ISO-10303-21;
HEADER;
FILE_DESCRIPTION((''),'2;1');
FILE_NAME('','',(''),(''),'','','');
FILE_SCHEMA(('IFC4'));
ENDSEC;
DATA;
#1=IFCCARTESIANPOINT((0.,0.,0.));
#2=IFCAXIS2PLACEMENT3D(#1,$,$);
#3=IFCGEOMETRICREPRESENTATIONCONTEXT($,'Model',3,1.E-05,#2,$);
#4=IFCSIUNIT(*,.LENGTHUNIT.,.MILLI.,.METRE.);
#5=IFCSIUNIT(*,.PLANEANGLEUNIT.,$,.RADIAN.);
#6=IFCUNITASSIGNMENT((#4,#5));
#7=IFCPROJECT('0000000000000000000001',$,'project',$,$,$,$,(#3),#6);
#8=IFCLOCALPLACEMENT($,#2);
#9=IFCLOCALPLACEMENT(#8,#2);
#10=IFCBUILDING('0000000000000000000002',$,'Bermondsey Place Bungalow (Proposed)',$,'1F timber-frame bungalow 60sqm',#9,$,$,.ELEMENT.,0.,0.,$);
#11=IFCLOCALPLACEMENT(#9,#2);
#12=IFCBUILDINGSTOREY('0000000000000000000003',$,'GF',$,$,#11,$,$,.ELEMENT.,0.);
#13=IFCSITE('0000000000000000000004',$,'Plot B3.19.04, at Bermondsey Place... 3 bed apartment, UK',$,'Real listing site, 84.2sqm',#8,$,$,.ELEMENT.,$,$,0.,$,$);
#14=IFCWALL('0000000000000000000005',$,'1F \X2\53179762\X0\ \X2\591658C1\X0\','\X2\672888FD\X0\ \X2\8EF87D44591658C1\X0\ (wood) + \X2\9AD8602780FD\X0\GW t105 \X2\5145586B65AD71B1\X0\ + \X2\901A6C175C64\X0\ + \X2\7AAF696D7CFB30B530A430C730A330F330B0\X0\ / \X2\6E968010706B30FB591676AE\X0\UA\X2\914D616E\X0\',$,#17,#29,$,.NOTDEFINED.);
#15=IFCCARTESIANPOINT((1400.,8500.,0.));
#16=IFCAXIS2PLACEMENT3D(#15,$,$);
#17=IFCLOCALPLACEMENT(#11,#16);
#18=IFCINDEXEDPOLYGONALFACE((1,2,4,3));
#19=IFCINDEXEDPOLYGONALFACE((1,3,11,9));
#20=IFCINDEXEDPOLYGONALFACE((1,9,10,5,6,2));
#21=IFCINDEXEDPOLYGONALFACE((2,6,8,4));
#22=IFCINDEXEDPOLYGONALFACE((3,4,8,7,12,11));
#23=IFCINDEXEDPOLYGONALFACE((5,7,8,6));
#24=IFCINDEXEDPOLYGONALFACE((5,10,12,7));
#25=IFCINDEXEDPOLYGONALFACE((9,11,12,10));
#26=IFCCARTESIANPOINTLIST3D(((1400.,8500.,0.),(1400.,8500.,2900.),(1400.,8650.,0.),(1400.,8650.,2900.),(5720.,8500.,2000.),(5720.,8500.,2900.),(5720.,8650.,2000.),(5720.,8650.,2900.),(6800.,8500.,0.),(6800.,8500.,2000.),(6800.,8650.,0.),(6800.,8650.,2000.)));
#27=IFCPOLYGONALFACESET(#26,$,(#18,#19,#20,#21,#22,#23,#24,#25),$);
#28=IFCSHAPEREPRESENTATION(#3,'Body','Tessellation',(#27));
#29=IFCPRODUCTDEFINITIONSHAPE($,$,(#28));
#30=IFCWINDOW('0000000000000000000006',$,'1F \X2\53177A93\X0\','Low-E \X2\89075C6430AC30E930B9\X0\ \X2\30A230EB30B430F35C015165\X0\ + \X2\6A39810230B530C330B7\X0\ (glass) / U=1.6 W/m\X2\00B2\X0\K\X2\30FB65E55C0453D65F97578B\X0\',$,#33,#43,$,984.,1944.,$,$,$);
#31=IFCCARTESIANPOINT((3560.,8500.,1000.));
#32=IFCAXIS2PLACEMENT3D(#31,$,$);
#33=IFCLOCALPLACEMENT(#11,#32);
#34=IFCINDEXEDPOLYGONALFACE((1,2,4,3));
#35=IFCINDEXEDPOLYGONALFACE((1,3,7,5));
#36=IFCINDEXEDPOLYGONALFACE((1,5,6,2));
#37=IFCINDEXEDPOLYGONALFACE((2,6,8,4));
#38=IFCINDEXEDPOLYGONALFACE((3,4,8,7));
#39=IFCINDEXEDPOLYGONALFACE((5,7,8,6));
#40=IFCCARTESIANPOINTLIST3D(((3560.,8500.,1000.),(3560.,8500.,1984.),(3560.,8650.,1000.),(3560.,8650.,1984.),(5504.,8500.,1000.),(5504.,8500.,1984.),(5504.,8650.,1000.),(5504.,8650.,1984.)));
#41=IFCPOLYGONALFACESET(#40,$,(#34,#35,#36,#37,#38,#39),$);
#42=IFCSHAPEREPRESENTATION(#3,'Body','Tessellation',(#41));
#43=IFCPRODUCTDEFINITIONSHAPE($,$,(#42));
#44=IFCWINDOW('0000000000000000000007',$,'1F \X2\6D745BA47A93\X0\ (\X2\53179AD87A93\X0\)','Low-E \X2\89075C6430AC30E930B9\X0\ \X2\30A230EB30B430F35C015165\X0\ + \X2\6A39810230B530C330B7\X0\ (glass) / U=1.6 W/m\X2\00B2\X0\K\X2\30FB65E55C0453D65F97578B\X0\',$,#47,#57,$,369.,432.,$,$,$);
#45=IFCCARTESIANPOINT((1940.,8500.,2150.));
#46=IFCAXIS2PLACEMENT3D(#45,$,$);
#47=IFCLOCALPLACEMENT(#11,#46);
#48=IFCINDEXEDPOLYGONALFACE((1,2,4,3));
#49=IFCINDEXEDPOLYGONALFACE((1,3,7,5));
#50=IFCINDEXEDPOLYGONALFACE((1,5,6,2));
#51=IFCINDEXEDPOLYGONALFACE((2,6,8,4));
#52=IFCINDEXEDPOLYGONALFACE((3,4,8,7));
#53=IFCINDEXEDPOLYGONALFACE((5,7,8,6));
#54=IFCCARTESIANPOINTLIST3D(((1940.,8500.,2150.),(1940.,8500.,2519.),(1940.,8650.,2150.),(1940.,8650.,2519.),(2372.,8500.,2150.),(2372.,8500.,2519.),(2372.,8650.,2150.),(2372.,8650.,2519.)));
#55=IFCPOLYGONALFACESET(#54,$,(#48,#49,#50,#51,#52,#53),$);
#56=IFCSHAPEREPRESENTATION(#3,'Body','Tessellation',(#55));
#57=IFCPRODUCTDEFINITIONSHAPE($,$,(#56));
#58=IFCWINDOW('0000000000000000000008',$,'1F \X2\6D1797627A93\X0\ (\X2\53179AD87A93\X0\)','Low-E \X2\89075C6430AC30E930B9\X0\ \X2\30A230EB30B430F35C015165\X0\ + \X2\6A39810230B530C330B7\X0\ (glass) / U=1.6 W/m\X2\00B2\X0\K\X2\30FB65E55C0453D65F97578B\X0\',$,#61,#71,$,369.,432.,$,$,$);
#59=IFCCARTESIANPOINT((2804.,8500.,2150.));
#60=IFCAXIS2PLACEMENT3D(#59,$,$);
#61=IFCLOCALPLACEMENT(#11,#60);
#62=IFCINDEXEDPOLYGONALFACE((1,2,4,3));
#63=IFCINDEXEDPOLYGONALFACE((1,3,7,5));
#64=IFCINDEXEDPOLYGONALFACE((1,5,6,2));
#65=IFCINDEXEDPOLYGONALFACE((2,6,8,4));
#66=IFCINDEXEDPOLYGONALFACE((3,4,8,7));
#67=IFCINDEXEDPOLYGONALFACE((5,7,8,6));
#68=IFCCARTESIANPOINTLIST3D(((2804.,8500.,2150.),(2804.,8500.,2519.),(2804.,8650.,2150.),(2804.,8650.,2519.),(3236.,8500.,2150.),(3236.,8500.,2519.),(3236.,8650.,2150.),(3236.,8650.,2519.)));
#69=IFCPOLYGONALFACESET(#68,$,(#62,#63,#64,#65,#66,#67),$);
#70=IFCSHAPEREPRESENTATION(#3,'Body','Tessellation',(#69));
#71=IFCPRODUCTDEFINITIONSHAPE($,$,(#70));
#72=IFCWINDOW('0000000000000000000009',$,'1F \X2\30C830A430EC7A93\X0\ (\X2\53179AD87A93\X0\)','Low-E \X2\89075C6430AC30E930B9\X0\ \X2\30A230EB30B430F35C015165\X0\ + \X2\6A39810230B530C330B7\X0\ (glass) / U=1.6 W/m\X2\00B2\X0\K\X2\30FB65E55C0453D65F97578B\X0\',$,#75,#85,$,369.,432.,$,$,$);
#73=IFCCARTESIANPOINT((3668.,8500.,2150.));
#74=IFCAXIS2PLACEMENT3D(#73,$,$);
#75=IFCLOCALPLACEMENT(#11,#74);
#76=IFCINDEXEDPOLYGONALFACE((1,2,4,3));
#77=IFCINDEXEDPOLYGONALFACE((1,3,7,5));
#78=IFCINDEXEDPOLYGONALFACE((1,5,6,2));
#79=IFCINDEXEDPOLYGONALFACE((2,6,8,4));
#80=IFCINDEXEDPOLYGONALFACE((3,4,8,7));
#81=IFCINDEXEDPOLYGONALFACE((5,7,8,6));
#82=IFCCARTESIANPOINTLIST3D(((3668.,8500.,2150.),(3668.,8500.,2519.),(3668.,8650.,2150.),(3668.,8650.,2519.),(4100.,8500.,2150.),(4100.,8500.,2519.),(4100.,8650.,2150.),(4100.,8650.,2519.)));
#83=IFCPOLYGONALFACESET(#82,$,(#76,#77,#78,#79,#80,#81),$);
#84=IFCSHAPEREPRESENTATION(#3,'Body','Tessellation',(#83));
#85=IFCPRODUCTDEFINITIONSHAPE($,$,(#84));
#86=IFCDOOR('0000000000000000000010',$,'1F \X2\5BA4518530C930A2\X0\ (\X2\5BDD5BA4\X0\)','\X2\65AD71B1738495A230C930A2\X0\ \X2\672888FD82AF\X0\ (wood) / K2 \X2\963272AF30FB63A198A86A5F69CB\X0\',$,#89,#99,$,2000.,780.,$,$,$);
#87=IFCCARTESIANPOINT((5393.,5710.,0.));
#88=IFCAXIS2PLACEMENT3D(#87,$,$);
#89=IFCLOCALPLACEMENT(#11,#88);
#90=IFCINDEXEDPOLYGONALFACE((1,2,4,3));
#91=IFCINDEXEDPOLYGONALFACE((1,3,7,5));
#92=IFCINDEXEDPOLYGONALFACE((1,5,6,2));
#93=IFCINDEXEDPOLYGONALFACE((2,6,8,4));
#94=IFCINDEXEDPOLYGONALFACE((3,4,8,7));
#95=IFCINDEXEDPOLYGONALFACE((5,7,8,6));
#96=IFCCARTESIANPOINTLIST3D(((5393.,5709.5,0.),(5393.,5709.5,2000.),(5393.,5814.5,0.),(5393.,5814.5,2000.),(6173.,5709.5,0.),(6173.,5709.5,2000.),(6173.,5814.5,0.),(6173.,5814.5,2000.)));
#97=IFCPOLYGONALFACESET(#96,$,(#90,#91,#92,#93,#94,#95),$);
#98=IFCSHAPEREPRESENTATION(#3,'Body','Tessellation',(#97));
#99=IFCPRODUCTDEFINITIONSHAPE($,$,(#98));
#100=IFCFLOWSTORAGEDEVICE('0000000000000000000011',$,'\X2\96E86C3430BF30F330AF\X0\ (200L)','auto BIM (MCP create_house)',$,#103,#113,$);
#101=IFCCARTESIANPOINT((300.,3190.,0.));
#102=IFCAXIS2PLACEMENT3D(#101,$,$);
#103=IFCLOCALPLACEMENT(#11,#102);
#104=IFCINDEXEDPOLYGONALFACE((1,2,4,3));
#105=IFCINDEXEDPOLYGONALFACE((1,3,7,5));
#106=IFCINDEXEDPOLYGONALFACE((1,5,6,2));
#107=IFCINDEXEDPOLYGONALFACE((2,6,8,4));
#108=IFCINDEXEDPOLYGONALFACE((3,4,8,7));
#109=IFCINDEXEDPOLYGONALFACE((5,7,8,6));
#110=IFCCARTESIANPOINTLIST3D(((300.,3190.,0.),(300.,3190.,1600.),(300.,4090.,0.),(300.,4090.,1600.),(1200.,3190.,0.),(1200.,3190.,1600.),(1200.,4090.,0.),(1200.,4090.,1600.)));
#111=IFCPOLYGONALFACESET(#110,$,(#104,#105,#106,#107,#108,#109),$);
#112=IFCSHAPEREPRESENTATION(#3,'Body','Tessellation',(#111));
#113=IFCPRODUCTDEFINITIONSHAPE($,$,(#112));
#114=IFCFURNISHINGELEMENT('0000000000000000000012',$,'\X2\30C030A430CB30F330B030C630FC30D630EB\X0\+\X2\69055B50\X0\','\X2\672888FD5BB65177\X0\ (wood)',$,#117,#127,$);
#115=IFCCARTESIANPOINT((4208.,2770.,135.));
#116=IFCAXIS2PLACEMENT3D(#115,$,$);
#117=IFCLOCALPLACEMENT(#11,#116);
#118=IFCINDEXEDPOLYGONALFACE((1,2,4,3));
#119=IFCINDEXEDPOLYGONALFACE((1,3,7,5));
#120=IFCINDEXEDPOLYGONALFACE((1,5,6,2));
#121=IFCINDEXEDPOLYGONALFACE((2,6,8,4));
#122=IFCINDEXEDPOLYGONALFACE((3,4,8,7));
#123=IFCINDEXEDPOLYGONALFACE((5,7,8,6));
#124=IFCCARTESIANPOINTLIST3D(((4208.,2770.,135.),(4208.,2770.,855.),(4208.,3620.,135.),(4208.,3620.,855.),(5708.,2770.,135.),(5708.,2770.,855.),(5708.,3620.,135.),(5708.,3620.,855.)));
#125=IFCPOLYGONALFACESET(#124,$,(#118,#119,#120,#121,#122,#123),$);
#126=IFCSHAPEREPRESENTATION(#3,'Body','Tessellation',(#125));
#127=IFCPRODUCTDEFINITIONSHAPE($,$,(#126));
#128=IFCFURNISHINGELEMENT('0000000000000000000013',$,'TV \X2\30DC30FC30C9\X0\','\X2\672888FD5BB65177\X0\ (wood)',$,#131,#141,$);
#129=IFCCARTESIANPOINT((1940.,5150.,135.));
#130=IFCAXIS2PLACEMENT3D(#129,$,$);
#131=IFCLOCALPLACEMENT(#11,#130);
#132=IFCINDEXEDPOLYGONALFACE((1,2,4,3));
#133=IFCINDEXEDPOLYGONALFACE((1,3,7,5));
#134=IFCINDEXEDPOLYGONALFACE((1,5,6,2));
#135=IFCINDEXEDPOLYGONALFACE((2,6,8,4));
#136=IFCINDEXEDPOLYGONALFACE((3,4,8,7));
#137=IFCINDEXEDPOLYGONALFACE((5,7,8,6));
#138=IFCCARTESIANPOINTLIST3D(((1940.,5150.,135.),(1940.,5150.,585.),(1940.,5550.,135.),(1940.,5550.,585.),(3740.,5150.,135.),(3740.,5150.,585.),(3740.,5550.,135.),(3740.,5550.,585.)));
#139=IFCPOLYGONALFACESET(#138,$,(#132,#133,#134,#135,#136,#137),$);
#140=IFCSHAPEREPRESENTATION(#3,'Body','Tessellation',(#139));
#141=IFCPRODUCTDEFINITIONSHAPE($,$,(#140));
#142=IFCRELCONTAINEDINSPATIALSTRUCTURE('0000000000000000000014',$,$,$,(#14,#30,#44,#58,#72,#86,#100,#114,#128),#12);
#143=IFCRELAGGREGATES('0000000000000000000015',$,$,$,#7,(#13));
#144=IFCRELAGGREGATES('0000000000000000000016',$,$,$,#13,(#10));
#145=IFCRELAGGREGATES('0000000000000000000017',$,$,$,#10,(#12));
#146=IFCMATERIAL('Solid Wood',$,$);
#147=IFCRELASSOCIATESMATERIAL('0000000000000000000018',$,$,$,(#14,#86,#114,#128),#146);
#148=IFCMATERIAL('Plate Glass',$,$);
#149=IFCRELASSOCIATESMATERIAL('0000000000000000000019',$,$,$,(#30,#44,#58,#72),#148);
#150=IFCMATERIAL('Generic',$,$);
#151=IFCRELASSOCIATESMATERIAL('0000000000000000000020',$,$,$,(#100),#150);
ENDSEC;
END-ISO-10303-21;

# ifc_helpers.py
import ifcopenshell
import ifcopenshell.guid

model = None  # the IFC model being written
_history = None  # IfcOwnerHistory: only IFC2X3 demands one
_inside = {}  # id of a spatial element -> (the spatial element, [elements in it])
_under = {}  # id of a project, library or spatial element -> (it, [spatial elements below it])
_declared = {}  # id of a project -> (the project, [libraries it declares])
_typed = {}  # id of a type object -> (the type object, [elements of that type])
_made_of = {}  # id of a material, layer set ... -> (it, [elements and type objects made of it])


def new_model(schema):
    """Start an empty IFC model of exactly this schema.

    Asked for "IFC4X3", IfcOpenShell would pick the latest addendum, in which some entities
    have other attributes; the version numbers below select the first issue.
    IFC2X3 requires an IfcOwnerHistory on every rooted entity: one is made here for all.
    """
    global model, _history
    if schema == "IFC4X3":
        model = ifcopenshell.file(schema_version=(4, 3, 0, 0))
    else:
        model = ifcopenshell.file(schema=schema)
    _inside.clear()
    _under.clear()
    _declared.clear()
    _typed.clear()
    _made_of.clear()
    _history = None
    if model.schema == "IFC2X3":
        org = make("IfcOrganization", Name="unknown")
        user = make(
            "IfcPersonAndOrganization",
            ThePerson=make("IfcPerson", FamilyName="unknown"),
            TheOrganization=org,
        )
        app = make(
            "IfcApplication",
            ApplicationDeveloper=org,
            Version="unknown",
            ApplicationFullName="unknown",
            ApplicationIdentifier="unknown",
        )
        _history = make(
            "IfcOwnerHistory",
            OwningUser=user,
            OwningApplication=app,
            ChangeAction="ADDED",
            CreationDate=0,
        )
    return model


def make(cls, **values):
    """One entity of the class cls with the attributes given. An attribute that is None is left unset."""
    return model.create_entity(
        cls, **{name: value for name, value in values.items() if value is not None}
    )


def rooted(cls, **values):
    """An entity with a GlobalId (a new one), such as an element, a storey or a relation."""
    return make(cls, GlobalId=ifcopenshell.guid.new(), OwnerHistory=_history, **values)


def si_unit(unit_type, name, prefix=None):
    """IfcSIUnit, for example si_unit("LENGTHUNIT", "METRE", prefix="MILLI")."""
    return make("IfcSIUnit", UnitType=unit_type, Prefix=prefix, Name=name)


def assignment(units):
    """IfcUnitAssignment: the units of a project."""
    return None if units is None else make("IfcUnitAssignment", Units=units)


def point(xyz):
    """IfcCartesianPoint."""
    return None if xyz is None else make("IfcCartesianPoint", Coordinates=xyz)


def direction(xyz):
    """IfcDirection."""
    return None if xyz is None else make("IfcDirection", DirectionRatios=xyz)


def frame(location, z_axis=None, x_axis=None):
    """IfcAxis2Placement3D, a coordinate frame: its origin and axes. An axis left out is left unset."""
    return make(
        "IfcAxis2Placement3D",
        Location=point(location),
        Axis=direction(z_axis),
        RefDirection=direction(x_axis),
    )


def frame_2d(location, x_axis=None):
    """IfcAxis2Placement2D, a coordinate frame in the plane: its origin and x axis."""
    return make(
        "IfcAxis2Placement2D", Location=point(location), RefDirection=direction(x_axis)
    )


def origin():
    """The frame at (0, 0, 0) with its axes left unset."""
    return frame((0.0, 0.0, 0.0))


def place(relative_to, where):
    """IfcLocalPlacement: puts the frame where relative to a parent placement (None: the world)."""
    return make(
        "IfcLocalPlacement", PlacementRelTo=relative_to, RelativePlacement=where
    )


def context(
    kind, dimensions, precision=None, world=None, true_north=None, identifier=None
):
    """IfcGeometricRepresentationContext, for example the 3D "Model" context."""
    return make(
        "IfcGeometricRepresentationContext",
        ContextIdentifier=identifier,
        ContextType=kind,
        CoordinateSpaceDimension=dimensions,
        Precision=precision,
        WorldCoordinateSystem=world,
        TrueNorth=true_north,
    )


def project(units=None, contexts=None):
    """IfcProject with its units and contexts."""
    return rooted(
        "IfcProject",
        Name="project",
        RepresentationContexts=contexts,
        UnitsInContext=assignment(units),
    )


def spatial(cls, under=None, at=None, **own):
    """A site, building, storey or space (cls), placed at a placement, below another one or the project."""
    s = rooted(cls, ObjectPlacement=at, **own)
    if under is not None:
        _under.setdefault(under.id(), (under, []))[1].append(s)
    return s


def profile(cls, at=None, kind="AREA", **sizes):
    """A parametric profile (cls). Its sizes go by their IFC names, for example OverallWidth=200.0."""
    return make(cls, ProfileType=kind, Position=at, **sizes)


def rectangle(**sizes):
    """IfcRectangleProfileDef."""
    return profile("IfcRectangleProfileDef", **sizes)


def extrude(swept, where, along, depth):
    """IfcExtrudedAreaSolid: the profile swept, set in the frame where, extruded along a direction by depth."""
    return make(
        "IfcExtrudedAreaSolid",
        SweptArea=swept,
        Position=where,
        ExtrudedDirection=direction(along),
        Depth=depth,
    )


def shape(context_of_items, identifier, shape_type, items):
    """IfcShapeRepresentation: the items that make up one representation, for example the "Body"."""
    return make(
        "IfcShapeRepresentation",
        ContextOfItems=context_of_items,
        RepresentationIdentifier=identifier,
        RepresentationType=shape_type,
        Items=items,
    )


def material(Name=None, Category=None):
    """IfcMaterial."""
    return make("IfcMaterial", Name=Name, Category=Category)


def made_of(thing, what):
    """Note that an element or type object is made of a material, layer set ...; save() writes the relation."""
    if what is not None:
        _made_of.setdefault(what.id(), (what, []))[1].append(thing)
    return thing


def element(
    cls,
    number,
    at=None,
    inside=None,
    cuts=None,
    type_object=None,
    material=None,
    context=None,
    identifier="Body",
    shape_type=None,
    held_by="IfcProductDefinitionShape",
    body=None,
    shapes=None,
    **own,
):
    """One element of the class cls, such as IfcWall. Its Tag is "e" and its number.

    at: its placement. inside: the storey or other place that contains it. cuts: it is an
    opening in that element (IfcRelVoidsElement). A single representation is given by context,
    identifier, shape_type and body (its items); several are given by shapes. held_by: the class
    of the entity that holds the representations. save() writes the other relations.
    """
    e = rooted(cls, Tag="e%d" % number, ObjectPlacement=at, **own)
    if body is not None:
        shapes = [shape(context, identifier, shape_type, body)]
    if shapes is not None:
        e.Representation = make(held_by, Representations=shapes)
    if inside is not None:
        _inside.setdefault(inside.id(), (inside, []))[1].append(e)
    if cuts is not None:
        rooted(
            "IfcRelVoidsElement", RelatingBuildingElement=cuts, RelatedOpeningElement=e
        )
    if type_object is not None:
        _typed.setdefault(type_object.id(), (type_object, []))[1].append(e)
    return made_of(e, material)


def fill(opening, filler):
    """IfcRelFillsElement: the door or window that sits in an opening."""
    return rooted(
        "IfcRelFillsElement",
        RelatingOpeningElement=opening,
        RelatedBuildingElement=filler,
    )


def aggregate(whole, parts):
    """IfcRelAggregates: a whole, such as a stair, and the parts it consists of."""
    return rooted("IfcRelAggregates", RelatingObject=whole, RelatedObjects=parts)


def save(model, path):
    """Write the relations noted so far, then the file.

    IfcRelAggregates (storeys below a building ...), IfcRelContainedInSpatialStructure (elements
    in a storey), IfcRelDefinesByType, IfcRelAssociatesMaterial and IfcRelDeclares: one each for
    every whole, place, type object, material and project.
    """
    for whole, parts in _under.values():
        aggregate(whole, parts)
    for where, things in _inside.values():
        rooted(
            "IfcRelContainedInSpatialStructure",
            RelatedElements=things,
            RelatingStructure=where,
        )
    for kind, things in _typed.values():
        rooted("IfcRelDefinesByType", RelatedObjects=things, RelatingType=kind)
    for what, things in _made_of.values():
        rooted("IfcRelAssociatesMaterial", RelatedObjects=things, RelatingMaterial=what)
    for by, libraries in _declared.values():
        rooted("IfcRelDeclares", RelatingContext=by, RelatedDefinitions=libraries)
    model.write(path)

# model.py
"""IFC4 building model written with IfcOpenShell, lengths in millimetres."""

from ifc_helpers import new_model, si_unit, frame, frame_2d, origin, place, context, project, spatial, rectangle, extrude, material, element, fill, save


model = new_model("IFC4")

# Units and contexts
model_context = context("Model", 3, precision=1e-05, world=origin())
ifc_project = project(units=[si_unit("LENGTHUNIT", "METRE", prefix="MILLI"), si_unit("PLANEANGLEUNIT", "RADIAN")], contexts=[model_context])

# Site, building, storey
site_placement = place(None, origin())
site = spatial("IfcSite", under=ifc_project, at=site_placement, Name="Plot B3.19.04, at Bermondsey Place... 3 bed apartment, UK", ObjectType="Real listing site, 84.2sqm", CompositionType="ELEMENT", RefElevation=0.0)
building_placement = place(site_placement, origin())
building = spatial("IfcBuilding", under=site, at=building_placement, Name="Bermondsey Place Bungalow (Proposed)", ObjectType="1F timber-frame bungalow 60sqm", CompositionType="ELEMENT", ElevationOfRefHeight=0.0, ElevationOfTerrain=0.0)
storey_placement = place(building_placement, origin())
storey = spatial("IfcBuildingStorey", under=building, at=storey_placement, Name="GF", CompositionType="ELEMENT", Elevation=0.0)

# Wall, openings, windows
ifc_material_1 = material(Name="Solid Wood")
wall_1_placement = place(storey_placement, frame((1400.0, 8500.0, 0.0)))
wall_1 = element("IfcWall", 1, at=wall_1_placement, inside=storey, material=ifc_material_1, Name="1F 北面 外壁", Description="木製 軸組外壁 (wood) + 高性能GW t105 充填断熱 + 通気層 + 窯業系サイディング / 準耐火・外皮UA配慮", PredefinedType="NOTDEFINED", context=model_context, shape_type="SweptSolid", body=[
    extrude(rectangle(XDim=5400.0, YDim=150.0, at=frame_2d((2700.0, 75.0))), frame((1400.0, 8500.0, 0.0)), (0.0, 0.0, 1.0), 2900.0),
])
opening_1_placement = place(storey_placement, frame((3560.0, 8500.0, 1000.0)))
opening_1 = element("IfcOpeningElement", 2, at=opening_1_placement, cuts=wall_1, PredefinedType="NOTDEFINED", context=model_context, shape_type="SweptSolid", body=[
    extrude(rectangle(XDim=1944.0, YDim=150.0, at=frame_2d((972.0, 75.0))), frame((3560.0, 8500.0, 1000.0)), (0.0, 0.0, 1.0), 984.0),
])
opening_2_placement = place(storey_placement, frame((1940.0, 8500.0, 2150.0)))
opening_2 = element("IfcOpeningElement", 3, at=opening_2_placement, cuts=wall_1, PredefinedType="NOTDEFINED", context=model_context, shape_type="SweptSolid", body=[
    extrude(rectangle(XDim=432.0, YDim=150.0, at=frame_2d((216.0, 75.0))), frame((1940.0, 8500.0, 2150.0)), (0.0, 0.0, 1.0), 369.0),
])
opening_3_placement = place(storey_placement, frame((2804.0, 8500.0, 2150.0)))
opening_3 = element("IfcOpeningElement", 4, at=opening_3_placement, cuts=wall_1, PredefinedType="NOTDEFINED", context=model_context, shape_type="SweptSolid", body=[
    extrude(rectangle(XDim=432.0, YDim=150.0, at=frame_2d((216.0, 75.0))), frame((2804.0, 8500.0, 2150.0)), (0.0, 0.0, 1.0), 369.0),
])
opening_4_placement = place(storey_placement, frame((3668.0, 8500.0, 2150.0)))
opening_4 = element("IfcOpeningElement", 5, at=opening_4_placement, cuts=wall_1, PredefinedType="NOTDEFINED", context=model_context, shape_type="SweptSolid", body=[
    extrude(rectangle(XDim=432.0, YDim=150.0, at=frame_2d((216.0, 75.0))), frame((3668.0, 8500.0, 2150.0)), (0.0, 0.0, 1.0), 369.0),
])
ifc_material_2 = material(Name="Plate Glass")
window_1_placement = place(storey_placement, frame((3560.0, 8500.0, 1000.0)))
window_1 = element("IfcWindow", 6, at=window_1_placement, inside=storey, material=ifc_material_2, Name="1F 北窓", Description="Low-E 複層ガラス アルゴン封入 + 樹脂サッシ (glass) / U=1.6 W/m²K・日射取得型", OverallHeight=984.0, OverallWidth=1944.0, context=model_context, shape_type="SweptSolid", body=[
    extrude(rectangle(XDim=1944.0, YDim=150.0, at=frame_2d((972.0, 75.0))), frame((3560.0, 8500.0, 1000.0)), (0.0, 0.0, 1.0), 984.0),
])
fill(opening_1, window_1)
window_2_placement = place(storey_placement, frame((1940.0, 8500.0, 2150.0)))
window_2 = element("IfcWindow", 7, at=window_2_placement, inside=storey, material=ifc_material_2, Name="1F 浴室窓 (北高窓)", Description="Low-E 複層ガラス アルゴン封入 + 樹脂サッシ (glass) / U=1.6 W/m²K・日射取得型", OverallHeight=369.0, OverallWidth=432.0, context=model_context, shape_type="SweptSolid", body=[
    extrude(rectangle(XDim=432.0, YDim=150.0, at=frame_2d((216.0, 75.0))), frame((1940.0, 8500.0, 2150.0)), (0.0, 0.0, 1.0), 369.0),
])
fill(opening_2, window_2)
window_3_placement = place(storey_placement, frame((2804.0, 8500.0, 2150.0)))
window_3 = element("IfcWindow", 8, at=window_3_placement, inside=storey, material=ifc_material_2, Name="1F 洗面窓 (北高窓)", Description="Low-E 複層ガラス アルゴン封入 + 樹脂サッシ (glass) / U=1.6 W/m²K・日射取得型", OverallHeight=369.0, OverallWidth=432.0, context=model_context, shape_type="SweptSolid", body=[
    extrude(rectangle(XDim=432.0, YDim=150.0, at=frame_2d((216.0, 75.0))), frame((2804.0, 8500.0, 2150.0)), (0.0, 0.0, 1.0), 369.0),
])
fill(opening_3, window_3)
window_4_placement = place(storey_placement, frame((3668.0, 8500.0, 2150.0)))
window_4 = element("IfcWindow", 9, at=window_4_placement, inside=storey, material=ifc_material_2, Name="1F トイレ窓 (北高窓)", Description="Low-E 複層ガラス アルゴン封入 + 樹脂サッシ (glass) / U=1.6 W/m²K・日射取得型", OverallHeight=369.0, OverallWidth=432.0, context=model_context, shape_type="SweptSolid", body=[
    extrude(rectangle(XDim=432.0, YDim=150.0, at=frame_2d((216.0, 75.0))), frame((3668.0, 8500.0, 2150.0)), (0.0, 0.0, 1.0), 369.0),
])
fill(opening_4, window_4)

# Door
door_1_placement = place(storey_placement, frame((5393.0, 5710.0, 0.0)))
element("IfcDoor", 10, at=door_1_placement, inside=storey, material=ifc_material_1, Name="1F 室内ドア (寝室)", Description="断熱玄関ドア 木製芯 (wood) / K2 防犯・採風機構", OverallHeight=2000.0, OverallWidth=780.0, context=model_context, shape_type="SweptSolid", body=[
    extrude(rectangle(XDim=780.0, YDim=105.0, at=frame_2d((390.0, 52.0))), frame((5393.0, 5710.0, 0.0)), (0.0, 0.0, 1.0), 2000.0),
])

# Flow storage device
ifc_material_3 = material(Name="Generic")
flow_storage_device_placement = place(storey_placement, frame((300.0, 3190.0, 0.0)))
element("IfcFlowStorageDevice", 11, at=flow_storage_device_placement, inside=storey, material=ifc_material_3, Name="雨水タンク (200L)", Description="auto BIM (MCP create_house)", context=model_context, shape_type="SweptSolid", body=[
    extrude(rectangle(XDim=900.0, YDim=900.0, at=frame_2d((450.0, 450.0))), frame((300.0, 3190.0, 0.0)), (0.0, 0.0, 1.0), 1600.0),
])

# Furnishing elements
furnishing_1_placement = place(storey_placement, frame((4208.0, 2770.0, 135.0)))
element("IfcFurnishingElement", 12, at=furnishing_1_placement, inside=storey, material=ifc_material_1, Name="ダイニングテーブル+椅子", Description="木製家具 (wood)", context=model_context, shape_type="SweptSolid", body=[
    extrude(rectangle(XDim=1500.0, YDim=850.0, at=frame_2d((750.0, 425.0))), frame((4208.0, 2770.0, 135.0)), (0.0, 0.0, 1.0), 720.0),
])
furnishing_2_placement = place(storey_placement, frame((1940.0, 5150.0, 135.0)))
element("IfcFurnishingElement", 13, at=furnishing_2_placement, inside=storey, material=ifc_material_1, Name="TV ボード", Description="木製家具 (wood)", context=model_context, shape_type="SweptSolid", body=[
    extrude(rectangle(XDim=1800.0, YDim=400.0, at=frame_2d((900.0, 200.0))), frame((1940.0, 5150.0, 135.0)), (0.0, 0.0, 1.0), 450.0),
])

save(model, "model.ifc")
